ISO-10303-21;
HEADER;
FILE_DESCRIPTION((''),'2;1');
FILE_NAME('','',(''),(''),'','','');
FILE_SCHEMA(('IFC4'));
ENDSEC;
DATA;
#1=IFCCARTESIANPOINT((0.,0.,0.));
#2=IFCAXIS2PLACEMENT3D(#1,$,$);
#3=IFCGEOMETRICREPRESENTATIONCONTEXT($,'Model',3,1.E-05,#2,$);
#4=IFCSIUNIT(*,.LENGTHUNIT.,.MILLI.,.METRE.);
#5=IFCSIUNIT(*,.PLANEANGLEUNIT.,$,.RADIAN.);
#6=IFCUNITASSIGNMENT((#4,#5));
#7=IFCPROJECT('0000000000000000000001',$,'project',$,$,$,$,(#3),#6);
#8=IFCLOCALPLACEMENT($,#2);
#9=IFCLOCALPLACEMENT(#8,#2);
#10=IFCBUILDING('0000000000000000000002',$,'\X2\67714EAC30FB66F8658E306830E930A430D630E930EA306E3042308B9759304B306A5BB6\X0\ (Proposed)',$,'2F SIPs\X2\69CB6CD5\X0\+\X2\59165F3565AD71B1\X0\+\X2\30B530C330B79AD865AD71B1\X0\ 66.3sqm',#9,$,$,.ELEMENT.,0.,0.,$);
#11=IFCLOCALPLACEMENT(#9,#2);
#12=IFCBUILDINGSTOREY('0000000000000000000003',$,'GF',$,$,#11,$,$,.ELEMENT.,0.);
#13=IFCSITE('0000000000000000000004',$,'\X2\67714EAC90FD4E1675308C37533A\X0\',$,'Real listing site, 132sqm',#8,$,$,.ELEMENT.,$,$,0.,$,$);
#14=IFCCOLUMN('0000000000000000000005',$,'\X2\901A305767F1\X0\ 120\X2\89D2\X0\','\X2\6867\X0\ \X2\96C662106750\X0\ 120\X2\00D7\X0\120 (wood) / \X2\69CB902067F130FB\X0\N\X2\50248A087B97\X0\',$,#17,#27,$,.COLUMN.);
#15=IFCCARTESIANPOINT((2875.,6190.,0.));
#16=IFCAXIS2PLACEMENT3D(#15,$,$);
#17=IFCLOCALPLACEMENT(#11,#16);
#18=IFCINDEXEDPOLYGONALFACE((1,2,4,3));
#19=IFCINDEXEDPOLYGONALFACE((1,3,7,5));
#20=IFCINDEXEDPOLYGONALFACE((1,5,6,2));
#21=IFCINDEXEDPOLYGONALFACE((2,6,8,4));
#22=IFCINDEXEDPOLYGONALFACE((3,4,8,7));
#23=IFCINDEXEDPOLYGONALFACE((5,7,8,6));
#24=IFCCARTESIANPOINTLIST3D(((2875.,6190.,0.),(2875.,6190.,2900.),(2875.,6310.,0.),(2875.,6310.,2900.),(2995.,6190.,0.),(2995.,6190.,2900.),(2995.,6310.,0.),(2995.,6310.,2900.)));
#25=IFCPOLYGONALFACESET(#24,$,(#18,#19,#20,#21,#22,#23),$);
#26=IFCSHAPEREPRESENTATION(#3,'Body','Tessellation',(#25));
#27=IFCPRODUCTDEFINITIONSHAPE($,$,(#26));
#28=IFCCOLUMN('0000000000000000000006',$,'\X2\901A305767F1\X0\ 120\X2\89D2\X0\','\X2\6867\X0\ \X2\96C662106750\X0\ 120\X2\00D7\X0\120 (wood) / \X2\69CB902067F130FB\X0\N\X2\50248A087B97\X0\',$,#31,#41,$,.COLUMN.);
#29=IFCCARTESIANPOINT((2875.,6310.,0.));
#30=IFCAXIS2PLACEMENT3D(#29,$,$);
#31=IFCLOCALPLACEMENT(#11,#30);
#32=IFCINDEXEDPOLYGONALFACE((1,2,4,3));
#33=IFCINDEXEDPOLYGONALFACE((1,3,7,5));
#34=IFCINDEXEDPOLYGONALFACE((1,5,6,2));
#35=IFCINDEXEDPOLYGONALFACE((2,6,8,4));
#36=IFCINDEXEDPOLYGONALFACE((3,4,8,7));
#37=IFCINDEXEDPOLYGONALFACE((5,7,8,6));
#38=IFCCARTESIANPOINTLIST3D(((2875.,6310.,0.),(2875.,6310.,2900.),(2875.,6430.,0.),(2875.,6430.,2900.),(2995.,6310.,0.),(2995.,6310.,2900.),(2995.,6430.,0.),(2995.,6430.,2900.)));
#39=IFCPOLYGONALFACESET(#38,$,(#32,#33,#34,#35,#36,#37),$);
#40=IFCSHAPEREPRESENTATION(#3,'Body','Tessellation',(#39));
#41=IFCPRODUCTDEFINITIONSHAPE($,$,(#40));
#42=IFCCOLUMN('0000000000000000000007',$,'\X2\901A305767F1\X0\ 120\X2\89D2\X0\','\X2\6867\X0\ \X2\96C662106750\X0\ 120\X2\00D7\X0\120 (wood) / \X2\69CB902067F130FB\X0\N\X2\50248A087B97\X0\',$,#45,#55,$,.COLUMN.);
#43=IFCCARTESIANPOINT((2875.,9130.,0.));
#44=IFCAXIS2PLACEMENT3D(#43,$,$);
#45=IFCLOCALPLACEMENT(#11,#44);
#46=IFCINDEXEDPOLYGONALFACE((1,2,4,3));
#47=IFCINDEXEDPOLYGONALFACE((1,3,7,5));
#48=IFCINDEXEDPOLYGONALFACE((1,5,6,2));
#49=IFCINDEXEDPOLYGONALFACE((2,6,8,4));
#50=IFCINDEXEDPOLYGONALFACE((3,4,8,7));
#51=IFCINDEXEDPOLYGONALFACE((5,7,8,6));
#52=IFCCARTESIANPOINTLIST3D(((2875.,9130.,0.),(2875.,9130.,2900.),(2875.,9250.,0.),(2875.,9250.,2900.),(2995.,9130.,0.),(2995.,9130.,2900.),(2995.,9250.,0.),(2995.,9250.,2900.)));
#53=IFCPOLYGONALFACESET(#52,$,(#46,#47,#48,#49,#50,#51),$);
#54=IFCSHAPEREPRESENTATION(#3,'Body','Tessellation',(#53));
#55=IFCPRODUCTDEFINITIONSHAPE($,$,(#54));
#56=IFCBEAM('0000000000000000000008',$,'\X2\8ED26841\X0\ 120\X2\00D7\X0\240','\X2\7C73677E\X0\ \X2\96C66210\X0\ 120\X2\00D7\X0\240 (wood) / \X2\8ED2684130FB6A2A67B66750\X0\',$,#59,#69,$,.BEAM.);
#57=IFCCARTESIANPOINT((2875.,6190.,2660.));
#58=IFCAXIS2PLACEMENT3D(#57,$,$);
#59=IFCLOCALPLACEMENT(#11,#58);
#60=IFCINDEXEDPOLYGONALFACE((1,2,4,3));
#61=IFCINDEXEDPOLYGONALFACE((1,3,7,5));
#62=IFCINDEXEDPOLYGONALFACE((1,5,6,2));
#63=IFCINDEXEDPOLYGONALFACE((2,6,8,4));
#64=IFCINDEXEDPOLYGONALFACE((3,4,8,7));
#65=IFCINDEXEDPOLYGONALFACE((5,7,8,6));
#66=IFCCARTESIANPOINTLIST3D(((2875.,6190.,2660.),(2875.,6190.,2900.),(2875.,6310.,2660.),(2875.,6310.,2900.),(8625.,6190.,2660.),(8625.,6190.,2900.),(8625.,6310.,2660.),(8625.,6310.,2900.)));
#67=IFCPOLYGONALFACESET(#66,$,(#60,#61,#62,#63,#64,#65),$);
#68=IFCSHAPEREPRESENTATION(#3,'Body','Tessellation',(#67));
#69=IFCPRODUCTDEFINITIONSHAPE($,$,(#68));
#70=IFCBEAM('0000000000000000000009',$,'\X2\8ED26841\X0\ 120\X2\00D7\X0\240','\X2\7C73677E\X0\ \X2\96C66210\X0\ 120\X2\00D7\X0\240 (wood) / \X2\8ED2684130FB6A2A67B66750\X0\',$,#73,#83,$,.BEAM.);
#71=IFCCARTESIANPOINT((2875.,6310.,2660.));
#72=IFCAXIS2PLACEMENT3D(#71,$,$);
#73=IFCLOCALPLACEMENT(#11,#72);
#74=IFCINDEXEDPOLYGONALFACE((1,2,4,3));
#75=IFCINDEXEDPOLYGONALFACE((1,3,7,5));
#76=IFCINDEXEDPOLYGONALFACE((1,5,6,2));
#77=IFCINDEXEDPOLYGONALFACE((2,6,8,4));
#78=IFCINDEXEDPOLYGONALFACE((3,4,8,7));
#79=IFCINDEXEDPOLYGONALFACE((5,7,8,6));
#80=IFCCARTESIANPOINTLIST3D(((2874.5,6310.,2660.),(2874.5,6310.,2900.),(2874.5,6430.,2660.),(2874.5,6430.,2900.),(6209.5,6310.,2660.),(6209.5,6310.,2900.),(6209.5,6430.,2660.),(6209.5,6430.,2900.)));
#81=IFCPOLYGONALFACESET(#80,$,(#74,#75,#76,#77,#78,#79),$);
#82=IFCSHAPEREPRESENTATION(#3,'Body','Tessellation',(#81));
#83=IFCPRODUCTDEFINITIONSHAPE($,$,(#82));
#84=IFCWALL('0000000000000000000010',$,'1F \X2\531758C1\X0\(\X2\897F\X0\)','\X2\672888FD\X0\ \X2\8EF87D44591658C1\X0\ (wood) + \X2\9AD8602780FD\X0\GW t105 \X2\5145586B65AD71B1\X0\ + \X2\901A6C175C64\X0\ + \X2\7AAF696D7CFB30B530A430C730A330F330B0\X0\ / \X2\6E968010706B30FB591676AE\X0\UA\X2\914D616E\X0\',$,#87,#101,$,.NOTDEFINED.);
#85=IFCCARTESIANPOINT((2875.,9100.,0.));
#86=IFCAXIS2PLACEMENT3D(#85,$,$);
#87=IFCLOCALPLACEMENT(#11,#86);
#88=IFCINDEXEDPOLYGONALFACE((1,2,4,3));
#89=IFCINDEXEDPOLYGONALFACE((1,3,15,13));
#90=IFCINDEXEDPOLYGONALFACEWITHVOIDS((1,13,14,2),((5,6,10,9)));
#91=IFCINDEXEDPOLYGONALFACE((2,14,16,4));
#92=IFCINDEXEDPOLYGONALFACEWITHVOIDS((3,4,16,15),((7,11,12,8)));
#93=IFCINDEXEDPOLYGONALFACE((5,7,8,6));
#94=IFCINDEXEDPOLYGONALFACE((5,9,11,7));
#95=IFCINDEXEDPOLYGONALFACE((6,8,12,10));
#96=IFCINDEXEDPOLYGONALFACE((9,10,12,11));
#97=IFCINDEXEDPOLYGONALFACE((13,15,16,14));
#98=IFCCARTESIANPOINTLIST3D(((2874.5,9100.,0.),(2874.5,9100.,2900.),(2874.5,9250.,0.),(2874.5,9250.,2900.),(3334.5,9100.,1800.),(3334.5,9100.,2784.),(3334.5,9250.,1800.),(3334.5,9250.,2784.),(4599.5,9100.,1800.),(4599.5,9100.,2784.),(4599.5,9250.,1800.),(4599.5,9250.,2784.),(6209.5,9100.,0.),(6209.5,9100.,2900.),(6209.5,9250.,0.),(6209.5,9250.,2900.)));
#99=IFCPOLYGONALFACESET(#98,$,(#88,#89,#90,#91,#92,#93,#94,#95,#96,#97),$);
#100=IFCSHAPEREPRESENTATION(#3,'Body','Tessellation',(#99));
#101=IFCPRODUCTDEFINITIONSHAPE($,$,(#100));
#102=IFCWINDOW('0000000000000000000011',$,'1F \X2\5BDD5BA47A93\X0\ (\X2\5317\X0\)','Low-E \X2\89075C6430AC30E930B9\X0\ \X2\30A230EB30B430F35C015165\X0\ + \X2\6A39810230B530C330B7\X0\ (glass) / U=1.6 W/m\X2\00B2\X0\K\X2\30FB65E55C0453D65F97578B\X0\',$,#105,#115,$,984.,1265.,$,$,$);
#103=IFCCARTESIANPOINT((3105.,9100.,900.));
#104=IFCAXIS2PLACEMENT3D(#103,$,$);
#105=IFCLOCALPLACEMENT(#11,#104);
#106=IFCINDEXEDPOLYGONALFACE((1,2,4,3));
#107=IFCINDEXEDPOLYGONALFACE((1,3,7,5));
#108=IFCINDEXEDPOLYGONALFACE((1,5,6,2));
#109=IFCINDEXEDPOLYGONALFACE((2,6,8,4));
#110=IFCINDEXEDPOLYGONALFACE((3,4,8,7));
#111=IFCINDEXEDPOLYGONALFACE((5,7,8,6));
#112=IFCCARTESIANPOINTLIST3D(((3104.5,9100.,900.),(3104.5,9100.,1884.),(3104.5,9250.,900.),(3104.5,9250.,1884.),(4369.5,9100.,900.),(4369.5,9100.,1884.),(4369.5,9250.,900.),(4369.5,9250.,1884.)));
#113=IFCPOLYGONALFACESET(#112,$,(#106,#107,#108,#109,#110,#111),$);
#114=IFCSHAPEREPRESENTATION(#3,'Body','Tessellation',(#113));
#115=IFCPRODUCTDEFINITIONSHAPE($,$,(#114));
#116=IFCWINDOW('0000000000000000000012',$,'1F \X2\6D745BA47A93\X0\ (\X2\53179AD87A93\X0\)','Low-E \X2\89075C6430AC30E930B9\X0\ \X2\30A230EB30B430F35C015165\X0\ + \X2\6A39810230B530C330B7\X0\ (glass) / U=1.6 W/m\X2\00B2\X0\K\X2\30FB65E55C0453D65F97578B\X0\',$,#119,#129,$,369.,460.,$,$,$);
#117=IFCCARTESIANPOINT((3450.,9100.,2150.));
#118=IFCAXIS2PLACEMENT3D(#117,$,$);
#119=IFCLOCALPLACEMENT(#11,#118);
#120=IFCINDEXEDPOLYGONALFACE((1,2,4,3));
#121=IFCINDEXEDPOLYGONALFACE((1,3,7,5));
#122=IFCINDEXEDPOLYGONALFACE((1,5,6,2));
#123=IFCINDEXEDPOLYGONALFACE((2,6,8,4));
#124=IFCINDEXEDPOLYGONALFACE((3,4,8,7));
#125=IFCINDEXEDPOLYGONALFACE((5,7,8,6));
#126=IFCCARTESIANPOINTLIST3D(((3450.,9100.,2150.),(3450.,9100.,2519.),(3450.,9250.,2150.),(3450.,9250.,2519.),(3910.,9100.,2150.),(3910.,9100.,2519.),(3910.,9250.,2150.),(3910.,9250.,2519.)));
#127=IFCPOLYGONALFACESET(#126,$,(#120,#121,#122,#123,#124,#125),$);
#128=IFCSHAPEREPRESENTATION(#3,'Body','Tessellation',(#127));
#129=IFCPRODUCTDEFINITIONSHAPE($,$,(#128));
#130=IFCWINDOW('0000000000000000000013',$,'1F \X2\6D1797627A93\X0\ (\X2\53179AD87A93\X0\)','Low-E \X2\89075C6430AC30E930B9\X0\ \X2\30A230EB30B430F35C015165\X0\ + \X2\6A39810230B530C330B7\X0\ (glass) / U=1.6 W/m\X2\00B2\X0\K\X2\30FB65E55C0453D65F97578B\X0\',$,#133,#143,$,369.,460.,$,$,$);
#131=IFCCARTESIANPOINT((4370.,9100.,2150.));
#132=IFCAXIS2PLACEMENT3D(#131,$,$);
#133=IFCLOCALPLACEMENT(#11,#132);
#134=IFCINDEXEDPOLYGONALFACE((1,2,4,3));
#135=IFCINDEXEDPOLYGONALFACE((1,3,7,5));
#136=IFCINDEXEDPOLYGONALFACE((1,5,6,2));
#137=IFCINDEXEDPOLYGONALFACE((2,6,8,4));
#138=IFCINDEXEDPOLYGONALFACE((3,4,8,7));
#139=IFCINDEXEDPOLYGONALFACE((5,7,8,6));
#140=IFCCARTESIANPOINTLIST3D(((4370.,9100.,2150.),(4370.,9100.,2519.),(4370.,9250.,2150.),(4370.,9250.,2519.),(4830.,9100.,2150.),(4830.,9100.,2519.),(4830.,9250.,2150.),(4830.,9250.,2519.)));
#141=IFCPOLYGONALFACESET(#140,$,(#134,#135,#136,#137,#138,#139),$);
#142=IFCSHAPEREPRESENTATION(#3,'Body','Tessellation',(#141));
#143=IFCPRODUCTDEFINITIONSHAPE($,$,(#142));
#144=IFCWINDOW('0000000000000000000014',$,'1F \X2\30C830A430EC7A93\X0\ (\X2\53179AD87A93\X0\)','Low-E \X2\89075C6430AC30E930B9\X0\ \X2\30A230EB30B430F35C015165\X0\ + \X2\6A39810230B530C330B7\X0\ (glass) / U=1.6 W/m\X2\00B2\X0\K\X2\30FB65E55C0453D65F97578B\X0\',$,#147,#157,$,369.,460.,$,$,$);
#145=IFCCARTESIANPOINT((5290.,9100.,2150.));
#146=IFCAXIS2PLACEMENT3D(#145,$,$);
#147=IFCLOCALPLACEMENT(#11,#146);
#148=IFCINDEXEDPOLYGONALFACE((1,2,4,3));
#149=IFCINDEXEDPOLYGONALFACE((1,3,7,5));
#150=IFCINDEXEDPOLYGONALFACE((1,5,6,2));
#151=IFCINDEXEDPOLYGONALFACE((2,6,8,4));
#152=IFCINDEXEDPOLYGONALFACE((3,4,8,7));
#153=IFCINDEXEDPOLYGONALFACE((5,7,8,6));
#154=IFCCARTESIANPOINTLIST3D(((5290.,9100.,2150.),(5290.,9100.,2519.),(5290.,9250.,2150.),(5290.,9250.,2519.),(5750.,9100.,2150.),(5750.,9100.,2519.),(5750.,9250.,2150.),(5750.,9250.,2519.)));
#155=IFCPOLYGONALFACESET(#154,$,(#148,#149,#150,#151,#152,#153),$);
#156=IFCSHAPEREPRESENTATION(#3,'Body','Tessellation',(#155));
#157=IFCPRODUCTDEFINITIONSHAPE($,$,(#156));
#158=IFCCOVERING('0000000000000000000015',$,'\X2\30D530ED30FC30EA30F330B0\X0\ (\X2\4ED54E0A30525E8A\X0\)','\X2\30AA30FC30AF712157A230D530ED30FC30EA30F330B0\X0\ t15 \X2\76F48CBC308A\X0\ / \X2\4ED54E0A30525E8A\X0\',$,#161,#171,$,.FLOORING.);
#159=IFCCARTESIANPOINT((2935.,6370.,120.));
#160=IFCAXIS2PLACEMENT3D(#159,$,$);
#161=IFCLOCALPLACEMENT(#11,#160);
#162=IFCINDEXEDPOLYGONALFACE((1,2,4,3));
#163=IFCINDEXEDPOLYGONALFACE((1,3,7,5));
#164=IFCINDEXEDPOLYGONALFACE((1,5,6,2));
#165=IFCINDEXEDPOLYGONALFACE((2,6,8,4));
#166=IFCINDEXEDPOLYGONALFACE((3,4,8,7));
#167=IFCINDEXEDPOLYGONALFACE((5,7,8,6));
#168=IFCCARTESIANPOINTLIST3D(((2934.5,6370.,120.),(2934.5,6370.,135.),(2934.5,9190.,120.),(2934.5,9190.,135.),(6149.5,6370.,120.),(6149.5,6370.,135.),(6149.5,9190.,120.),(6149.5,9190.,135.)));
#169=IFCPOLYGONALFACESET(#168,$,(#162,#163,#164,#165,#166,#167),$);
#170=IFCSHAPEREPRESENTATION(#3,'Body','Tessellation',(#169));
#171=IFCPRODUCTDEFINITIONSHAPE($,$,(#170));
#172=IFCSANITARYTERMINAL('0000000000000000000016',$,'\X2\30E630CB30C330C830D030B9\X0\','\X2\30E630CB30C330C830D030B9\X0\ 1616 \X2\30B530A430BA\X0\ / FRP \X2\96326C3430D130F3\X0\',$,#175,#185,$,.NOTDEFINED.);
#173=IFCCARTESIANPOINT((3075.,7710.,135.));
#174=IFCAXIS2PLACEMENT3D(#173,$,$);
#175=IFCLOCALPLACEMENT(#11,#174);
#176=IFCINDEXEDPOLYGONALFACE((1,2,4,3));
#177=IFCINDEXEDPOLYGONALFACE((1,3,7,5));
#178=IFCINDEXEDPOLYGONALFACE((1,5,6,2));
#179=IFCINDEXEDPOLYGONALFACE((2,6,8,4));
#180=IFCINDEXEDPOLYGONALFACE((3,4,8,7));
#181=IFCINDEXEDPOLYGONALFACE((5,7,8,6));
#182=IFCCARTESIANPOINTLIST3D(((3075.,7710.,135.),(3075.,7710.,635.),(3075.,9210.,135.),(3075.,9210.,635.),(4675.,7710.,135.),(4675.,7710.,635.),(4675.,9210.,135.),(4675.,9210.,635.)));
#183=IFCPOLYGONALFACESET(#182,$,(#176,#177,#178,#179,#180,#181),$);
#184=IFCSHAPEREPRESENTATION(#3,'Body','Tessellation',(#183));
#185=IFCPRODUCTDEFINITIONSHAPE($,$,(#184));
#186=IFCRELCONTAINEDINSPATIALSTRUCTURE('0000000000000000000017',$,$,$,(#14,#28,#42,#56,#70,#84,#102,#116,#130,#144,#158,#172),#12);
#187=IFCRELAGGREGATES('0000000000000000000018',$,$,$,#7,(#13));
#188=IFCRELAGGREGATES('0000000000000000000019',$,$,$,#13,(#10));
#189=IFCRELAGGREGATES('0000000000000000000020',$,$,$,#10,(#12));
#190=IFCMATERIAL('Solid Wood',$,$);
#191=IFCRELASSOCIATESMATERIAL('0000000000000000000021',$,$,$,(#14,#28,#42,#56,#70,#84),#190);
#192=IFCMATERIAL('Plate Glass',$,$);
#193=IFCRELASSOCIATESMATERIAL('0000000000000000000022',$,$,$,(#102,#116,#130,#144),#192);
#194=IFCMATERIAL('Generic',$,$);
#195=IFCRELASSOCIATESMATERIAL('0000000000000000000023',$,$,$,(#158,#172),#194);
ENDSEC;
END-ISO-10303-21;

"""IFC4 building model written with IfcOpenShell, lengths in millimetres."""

from ifc_helpers import new_model, si_unit, frame, frame_2d, origin, place, context, project, spatial, rectangle, extrude, material, element, fill, save


model = new_model("IFC4")

# Units and contexts
model_context = context("Model", 3, precision=1e-05, world=origin())
ifc_project = project(units=[si_unit("LENGTHUNIT", "METRE", prefix="MILLI"), si_unit("PLANEANGLEUNIT", "RADIAN")], contexts=[model_context])

# Site, building, storey
site_placement = place(None, origin())
site = spatial("IfcSite", under=ifc_project, at=site_placement, Name="東京都世田谷区", ObjectType="Real listing site, 132sqm", CompositionType="ELEMENT", RefElevation=0.0)
building_placement = place(site_placement, origin())
building = spatial("IfcBuilding", under=site, at=building_placement, Name="東京・書斎とライブラリのある静かな家 (Proposed)", ObjectType="2F SIPs構法+外張断熱+サッシ高断熱 66.3sqm", CompositionType="ELEMENT", ElevationOfRefHeight=0.0, ElevationOfTerrain=0.0)
storey_placement = place(building_placement, origin())
storey = spatial("IfcBuildingStorey", under=building, at=storey_placement, Name="GF", CompositionType="ELEMENT", Elevation=0.0)

# Columns
ifc_material_1 = material(Name="Solid Wood")
column_1_placement = place(storey_placement, frame((2875.0, 6190.0, 0.0)))
element("IfcColumn", 1, at=column_1_placement, inside=storey, material=ifc_material_1, Name="通し柱 120角", Description="桧 集成材 120×120 (wood) / 構造柱・N値計算", PredefinedType="COLUMN", context=model_context, shape_type="SweptSolid", body=[
    extrude(rectangle(XDim=120.0, YDim=120.0, at=frame_2d((60.0, 60.0))), frame((2875.0, 6190.0, 0.0)), (0.0, 0.0, 1.0), 2900.0),
])
column_2_placement = place(storey_placement, frame((2875.0, 6310.0, 0.0)))
element("IfcColumn", 2, at=column_2_placement, inside=storey, material=ifc_material_1, Name="通し柱 120角", Description="桧 集成材 120×120 (wood) / 構造柱・N値計算", PredefinedType="COLUMN", context=model_context, shape_type="SweptSolid", body=[
    extrude(rectangle(XDim=120.0, YDim=120.0, at=frame_2d((60.0, 60.0))), frame((2875.0, 6310.0, 0.0)), (0.0, 0.0, 1.0), 2900.0),
])
column_3_placement = place(storey_placement, frame((2875.0, 9130.0, 0.0)))
element("IfcColumn", 3, at=column_3_placement, inside=storey, material=ifc_material_1, Name="通し柱 120角", Description="桧 集成材 120×120 (wood) / 構造柱・N値計算", PredefinedType="COLUMN", context=model_context, shape_type="SweptSolid", body=[
    extrude(rectangle(XDim=120.0, YDim=120.0, at=frame_2d((60.0, 60.0))), frame((2875.0, 9130.0, 0.0)), (0.0, 0.0, 1.0), 2900.0),
])

# Beams
beam_1_placement = place(storey_placement, frame((2875.0, 6190.0, 2660.0)))
element("IfcBeam", 4, at=beam_1_placement, inside=storey, material=ifc_material_1, Name="軒桁 120×240", Description="米松 集成 120×240 (wood) / 軒桁・横架材", PredefinedType="BEAM", context=model_context, shape_type="SweptSolid", body=[
    extrude(rectangle(XDim=5750.0, YDim=120.0, at=frame_2d((2875.0, 60.0))), frame((2875.0, 6190.0, 2660.0)), (0.0, 0.0, 1.0), 240.0),
])
beam_2_placement = place(storey_placement, frame((2875.0, 6310.0, 2660.0)))
element("IfcBeam", 5, at=beam_2_placement, inside=storey, material=ifc_material_1, Name="軒桁 120×240", Description="米松 集成 120×240 (wood) / 軒桁・横架材", PredefinedType="BEAM", context=model_context, shape_type="SweptSolid", body=[
    extrude(rectangle(XDim=3335.0, YDim=120.0, at=frame_2d((1667.0, 60.0))), frame((2875.0, 6310.0, 2660.0)), (0.0, 0.0, 1.0), 240.0),
])

# Wall, openings, windows
wall_1_placement = place(storey_placement, frame((2875.0, 9100.0, 0.0)))
wall_1 = element("IfcWall", 6, at=wall_1_placement, inside=storey, material=ifc_material_1, Name="1F 北壁(西)", Description="木製 軸組外壁 (wood) + 高性能GW t105 充填断熱 + 通気層 + 窯業系サイディング / 準耐火・外皮UA配慮", PredefinedType="NOTDEFINED", context=model_context, shape_type="SweptSolid", body=[
    extrude(rectangle(XDim=3335.0, YDim=150.0, at=frame_2d((1667.0, 75.0))), frame((2875.0, 9100.0, 0.0)), (0.0, 0.0, 1.0), 2900.0),
])
opening_1_placement = place(storey_placement, frame((3105.0, 9100.0, 900.0)))
opening_1 = element("IfcOpeningElement", 7, at=opening_1_placement, cuts=wall_1, PredefinedType="NOTDEFINED", context=model_context, shape_type="SweptSolid", body=[
    extrude(rectangle(XDim=1265.0, YDim=150.0, at=frame_2d((632.0, 75.0))), frame((3105.0, 9100.0, 900.0)), (0.0, 0.0, 1.0), 984.0),
])
opening_2_placement = place(storey_placement, frame((3450.0, 9100.0, 2150.0)))
opening_2 = element("IfcOpeningElement", 8, at=opening_2_placement, cuts=wall_1, PredefinedType="NOTDEFINED", context=model_context, shape_type="SweptSolid", body=[
    extrude(rectangle(XDim=460.0, YDim=150.0, at=frame_2d((230.0, 75.0))), frame((3450.0, 9100.0, 2150.0)), (0.0, 0.0, 1.0), 369.0),
])
opening_3_placement = place(storey_placement, frame((4370.0, 9100.0, 2150.0)))
opening_3 = element("IfcOpeningElement", 9, at=opening_3_placement, cuts=wall_1, PredefinedType="NOTDEFINED", context=model_context, shape_type="SweptSolid", body=[
    extrude(rectangle(XDim=460.0, YDim=150.0, at=frame_2d((230.0, 75.0))), frame((4370.0, 9100.0, 2150.0)), (0.0, 0.0, 1.0), 369.0),
])
opening_4_placement = place(storey_placement, frame((5290.0, 9100.0, 2150.0)))
opening_4 = element("IfcOpeningElement", 10, at=opening_4_placement, cuts=wall_1, PredefinedType="NOTDEFINED", context=model_context, shape_type="SweptSolid", body=[
    extrude(rectangle(XDim=460.0, YDim=150.0, at=frame_2d((230.0, 75.0))), frame((5290.0, 9100.0, 2150.0)), (0.0, 0.0, 1.0), 369.0),
])
ifc_material_2 = material(Name="Plate Glass")
window_1_placement = place(storey_placement, frame((3105.0, 9100.0, 900.0)))
window_1 = element("IfcWindow", 11, at=window_1_placement, inside=storey, material=ifc_material_2, Name="1F 寝室窓 (北)", Description="Low-E 複層ガラス アルゴン封入 + 樹脂サッシ (glass) / U=1.6 W/m²K・日射取得型", OverallHeight=984.0, OverallWidth=1265.0, context=model_context, shape_type="SweptSolid", body=[
    extrude(rectangle(XDim=1265.0, YDim=150.0, at=frame_2d((632.0, 75.0))), frame((3105.0, 9100.0, 900.0)), (0.0, 0.0, 1.0), 984.0),
])
fill(opening_1, window_1)
window_2_placement = place(storey_placement, frame((3450.0, 9100.0, 2150.0)))
window_2 = element("IfcWindow", 12, at=window_2_placement, inside=storey, material=ifc_material_2, Name="1F 浴室窓 (北高窓)", Description="Low-E 複層ガラス アルゴン封入 + 樹脂サッシ (glass) / U=1.6 W/m²K・日射取得型", OverallHeight=369.0, OverallWidth=460.0, context=model_context, shape_type="SweptSolid", body=[
    extrude(rectangle(XDim=460.0, YDim=150.0, at=frame_2d((230.0, 75.0))), frame((3450.0, 9100.0, 2150.0)), (0.0, 0.0, 1.0), 369.0),
])
fill(opening_2, window_2)
window_3_placement = place(storey_placement, frame((4370.0, 9100.0, 2150.0)))
window_3 = element("IfcWindow", 13, at=window_3_placement, inside=storey, material=ifc_material_2, Name="1F 洗面窓 (北高窓)", Description="Low-E 複層ガラス アルゴン封入 + 樹脂サッシ (glass) / U=1.6 W/m²K・日射取得型", OverallHeight=369.0, OverallWidth=460.0, context=model_context, shape_type="SweptSolid", body=[
    extrude(rectangle(XDim=460.0, YDim=150.0, at=frame_2d((230.0, 75.0))), frame((4370.0, 9100.0, 2150.0)), (0.0, 0.0, 1.0), 369.0),
])
fill(opening_3, window_3)
window_4_placement = place(storey_placement, frame((5290.0, 9100.0, 2150.0)))
window_4 = element("IfcWindow", 14, at=window_4_placement, inside=storey, material=ifc_material_2, Name="1F トイレ窓 (北高窓)", Description="Low-E 複層ガラス アルゴン封入 + 樹脂サッシ (glass) / U=1.6 W/m²K・日射取得型", OverallHeight=369.0, OverallWidth=460.0, context=model_context, shape_type="SweptSolid", body=[
    extrude(rectangle(XDim=460.0, YDim=150.0, at=frame_2d((230.0, 75.0))), frame((5290.0, 9100.0, 2150.0)), (0.0, 0.0, 1.0), 369.0),
])
fill(opening_4, window_4)

# Covering
ifc_material_3 = material(Name="Generic")
covering_placement = place(storey_placement, frame((2935.0, 6370.0, 120.0)))
element("IfcCovering", 15, at=covering_placement, inside=storey, material=ifc_material_3, Name="フローリング (仕上げ床)", Description="オーク無垢フローリング t15 直貼り / 仕上げ床", PredefinedType="FLOORING", context=model_context, shape_type="SweptSolid", body=[
    extrude(rectangle(XDim=3215.0, YDim=2820.0, at=frame_2d((1607.0, 1410.0))), frame((2935.0, 6370.0, 120.0)), (0.0, 0.0, 1.0), 15.0),
])

# Sanitary terminal
sanitary_terminal_placement = place(storey_placement, frame((3075.0, 7710.0, 135.0)))
element("IfcSanitaryTerminal", 16, at=sanitary_terminal_placement, inside=storey, material=ifc_material_3, Name="ユニットバス", Description="ユニットバス 1616 サイズ / FRP 防水パン", PredefinedType="NOTDEFINED", context=model_context, shape_type="SweptSolid", body=[
    extrude(rectangle(XDim=1600.0, YDim=1500.0, at=frame_2d((800.0, 750.0))), frame((3075.0, 7710.0, 135.0)), (0.0, 0.0, 1.0), 500.0),
])

save(model, "model.ifc")
